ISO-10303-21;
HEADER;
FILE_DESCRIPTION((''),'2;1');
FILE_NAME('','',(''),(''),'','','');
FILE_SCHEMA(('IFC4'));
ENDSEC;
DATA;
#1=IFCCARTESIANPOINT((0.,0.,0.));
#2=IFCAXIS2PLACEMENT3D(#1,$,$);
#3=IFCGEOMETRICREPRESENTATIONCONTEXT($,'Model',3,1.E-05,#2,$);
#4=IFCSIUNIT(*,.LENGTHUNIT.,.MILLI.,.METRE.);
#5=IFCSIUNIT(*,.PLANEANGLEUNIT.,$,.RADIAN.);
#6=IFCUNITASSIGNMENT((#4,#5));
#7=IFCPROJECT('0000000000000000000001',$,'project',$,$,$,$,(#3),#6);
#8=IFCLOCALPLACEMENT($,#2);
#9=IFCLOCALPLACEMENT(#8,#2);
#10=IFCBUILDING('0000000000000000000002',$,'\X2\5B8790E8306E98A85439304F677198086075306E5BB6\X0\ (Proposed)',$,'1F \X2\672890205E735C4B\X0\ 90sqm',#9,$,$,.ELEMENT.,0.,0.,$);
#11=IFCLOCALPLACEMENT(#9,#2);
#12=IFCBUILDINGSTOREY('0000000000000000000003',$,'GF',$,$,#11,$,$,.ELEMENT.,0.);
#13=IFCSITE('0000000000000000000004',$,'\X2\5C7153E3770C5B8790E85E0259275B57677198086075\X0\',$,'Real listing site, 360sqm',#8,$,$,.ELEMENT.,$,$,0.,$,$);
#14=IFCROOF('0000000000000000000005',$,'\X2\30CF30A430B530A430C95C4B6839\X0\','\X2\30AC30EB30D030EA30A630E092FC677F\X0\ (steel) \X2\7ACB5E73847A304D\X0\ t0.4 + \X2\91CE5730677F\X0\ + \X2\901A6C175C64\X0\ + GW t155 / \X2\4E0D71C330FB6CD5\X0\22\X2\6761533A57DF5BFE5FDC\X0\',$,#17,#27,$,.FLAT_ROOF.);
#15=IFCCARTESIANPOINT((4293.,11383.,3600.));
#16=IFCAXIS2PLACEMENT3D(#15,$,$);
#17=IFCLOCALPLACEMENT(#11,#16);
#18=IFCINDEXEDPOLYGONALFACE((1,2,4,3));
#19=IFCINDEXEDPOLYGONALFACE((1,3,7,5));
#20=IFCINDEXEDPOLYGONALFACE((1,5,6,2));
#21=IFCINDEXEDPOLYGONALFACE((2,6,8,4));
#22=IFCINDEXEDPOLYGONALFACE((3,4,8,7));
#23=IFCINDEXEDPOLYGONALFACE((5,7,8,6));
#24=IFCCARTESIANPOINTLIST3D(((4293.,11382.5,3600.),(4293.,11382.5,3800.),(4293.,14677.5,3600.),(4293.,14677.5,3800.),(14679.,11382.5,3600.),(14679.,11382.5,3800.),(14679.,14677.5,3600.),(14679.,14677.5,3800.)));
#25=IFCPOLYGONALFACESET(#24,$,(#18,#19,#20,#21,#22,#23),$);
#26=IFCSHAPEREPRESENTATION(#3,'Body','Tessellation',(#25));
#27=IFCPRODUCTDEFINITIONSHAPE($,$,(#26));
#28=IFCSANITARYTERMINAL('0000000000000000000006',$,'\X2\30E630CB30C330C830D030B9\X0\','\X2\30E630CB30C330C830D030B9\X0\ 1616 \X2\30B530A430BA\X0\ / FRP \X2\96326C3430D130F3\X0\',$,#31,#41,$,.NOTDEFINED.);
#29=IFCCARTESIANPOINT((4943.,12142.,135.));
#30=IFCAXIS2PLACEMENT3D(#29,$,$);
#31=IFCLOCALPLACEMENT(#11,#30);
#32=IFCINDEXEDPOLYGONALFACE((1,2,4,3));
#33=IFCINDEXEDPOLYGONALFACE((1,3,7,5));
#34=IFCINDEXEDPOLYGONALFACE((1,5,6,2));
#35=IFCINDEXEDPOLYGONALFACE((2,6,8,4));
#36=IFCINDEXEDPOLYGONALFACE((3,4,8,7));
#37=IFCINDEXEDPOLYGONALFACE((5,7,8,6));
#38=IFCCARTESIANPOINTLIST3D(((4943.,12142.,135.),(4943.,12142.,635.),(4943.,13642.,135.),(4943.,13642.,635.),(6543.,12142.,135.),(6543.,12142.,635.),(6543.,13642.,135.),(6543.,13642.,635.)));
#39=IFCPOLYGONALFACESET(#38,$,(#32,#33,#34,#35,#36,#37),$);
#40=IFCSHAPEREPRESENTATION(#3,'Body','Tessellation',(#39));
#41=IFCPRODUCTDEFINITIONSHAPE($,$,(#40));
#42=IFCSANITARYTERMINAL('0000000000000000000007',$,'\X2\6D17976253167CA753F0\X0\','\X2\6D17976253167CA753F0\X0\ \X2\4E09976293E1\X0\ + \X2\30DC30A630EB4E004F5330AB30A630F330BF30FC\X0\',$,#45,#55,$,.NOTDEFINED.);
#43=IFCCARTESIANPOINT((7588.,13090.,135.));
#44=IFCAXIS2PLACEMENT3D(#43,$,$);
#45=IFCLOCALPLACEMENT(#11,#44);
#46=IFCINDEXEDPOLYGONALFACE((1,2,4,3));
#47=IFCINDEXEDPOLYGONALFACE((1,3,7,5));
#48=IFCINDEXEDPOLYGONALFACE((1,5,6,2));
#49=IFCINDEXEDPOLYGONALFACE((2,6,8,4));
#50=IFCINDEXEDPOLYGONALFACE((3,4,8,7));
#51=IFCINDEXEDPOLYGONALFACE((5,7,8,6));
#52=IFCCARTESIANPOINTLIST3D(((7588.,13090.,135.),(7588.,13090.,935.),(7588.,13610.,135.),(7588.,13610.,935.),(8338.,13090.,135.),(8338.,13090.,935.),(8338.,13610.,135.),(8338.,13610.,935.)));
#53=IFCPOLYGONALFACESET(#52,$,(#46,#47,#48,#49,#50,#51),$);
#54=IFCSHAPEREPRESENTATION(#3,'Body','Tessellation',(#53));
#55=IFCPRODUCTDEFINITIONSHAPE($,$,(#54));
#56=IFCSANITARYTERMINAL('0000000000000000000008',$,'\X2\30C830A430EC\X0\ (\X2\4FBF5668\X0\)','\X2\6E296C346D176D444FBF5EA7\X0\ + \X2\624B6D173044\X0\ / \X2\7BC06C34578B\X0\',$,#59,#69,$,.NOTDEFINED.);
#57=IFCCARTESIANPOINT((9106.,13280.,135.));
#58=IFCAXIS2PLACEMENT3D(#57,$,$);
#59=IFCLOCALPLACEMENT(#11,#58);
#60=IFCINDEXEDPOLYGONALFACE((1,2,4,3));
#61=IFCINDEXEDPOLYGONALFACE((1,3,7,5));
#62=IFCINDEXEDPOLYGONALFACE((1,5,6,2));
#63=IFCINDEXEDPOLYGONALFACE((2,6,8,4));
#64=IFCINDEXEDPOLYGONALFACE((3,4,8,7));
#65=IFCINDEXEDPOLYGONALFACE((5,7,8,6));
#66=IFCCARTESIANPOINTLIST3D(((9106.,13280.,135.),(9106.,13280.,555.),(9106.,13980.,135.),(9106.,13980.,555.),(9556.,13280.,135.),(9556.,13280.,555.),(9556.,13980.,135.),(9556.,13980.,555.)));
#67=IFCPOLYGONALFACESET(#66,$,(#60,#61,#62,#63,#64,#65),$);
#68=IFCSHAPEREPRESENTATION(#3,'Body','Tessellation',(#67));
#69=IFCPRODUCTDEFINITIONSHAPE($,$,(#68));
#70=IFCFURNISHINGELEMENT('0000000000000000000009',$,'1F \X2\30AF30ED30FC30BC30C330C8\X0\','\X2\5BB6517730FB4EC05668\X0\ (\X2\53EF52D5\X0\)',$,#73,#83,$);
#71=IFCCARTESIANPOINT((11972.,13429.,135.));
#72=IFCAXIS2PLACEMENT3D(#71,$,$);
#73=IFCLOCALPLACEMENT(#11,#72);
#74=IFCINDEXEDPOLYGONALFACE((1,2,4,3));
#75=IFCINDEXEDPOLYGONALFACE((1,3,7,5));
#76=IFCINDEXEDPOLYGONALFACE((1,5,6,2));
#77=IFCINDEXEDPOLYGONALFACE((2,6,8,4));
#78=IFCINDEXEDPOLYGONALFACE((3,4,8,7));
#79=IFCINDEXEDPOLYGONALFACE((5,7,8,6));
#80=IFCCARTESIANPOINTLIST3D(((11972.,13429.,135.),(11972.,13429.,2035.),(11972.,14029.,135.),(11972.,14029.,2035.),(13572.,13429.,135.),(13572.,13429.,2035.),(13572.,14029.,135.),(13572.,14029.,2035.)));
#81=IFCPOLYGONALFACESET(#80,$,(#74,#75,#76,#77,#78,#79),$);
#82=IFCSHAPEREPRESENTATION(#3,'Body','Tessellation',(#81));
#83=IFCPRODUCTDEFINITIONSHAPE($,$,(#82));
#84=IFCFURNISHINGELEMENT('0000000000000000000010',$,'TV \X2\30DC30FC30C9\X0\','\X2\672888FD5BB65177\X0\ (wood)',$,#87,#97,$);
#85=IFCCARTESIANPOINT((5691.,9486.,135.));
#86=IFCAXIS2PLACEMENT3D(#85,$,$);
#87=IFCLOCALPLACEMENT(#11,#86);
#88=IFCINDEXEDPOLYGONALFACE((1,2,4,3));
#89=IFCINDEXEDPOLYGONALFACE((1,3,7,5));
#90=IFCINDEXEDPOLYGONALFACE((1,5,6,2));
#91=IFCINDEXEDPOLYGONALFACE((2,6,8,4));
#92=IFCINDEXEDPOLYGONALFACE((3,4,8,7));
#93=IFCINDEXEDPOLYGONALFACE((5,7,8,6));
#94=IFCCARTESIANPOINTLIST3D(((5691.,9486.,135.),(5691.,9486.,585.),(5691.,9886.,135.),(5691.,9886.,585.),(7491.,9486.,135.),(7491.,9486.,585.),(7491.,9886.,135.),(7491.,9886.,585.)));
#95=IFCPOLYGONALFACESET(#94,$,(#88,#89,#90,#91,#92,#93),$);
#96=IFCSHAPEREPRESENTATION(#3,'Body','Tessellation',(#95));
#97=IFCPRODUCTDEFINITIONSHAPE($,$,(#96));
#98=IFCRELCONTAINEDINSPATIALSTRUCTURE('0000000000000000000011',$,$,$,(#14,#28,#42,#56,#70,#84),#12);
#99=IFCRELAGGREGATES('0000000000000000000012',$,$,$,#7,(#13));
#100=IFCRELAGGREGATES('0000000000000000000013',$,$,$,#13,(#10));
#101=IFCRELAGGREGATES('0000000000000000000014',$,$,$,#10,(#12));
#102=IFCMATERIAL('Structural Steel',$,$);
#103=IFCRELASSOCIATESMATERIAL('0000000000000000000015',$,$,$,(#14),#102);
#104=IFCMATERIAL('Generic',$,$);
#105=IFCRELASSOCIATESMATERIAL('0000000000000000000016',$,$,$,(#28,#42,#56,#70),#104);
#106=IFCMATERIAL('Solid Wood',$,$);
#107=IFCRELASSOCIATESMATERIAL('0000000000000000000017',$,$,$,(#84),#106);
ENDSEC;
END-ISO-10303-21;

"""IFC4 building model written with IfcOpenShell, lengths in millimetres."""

from ifc_helpers import new_model, si_unit, frame, frame_2d, origin, place, context, project, spatial, rectangle, extrude, material, element, save


model = new_model("IFC4")

# Units and contexts
model_context = context("Model", 3, precision=1e-05, world=origin())
ifc_project = project(units=[si_unit("LENGTHUNIT", "METRE", prefix="MILLI"), si_unit("PLANEANGLEUNIT", "RADIAN")], contexts=[model_context])

# Site, building, storey
site_placement = place(None, origin())
site = spatial("IfcSite", under=ifc_project, at=site_placement, Name="山口県宇部市大字東須恵", ObjectType="Real listing site, 360sqm", CompositionType="ELEMENT", RefElevation=0.0)
building_placement = place(site_placement, origin())
building = spatial("IfcBuilding", under=site, at=building_placement, Name="宇部の風吹く東須恵の家 (Proposed)", ObjectType="1F 木造平屋 90sqm", CompositionType="ELEMENT", ElevationOfRefHeight=0.0, ElevationOfTerrain=0.0)
storey_placement = place(building_placement, origin())
storey = spatial("IfcBuildingStorey", under=building, at=storey_placement, Name="GF", CompositionType="ELEMENT", Elevation=0.0)

# Shared definitions
ifc_material_1 = material(Name="Solid Wood")

# Roof
ifc_material_2 = material(Name="Structural Steel")
roof_placement = place(storey_placement, frame((4293.0, 11383.0, 3600.0)))
element("IfcRoof", 1, at=roof_placement, inside=storey, material=ifc_material_2, Name="ハイサイド屋根", Description="ガルバリウム鋼板 (steel) 立平葺き t0.4 + 野地板 + 通気層 + GW t155 / 不燃・法22条区域対応", PredefinedType="FLAT_ROOF", context=model_context, shape_type="SweptSolid", body=[
    extrude(rectangle(XDim=10386.0, YDim=3295.0, at=frame_2d((5193.0, 1647.0))), frame((4293.0, 11383.0, 3600.0)), (0.0, 0.0, 1.0), 200.0),
])

# Sanitary terminals
ifc_material_3 = material(Name="Generic")
sanitary_terminal_1_placement = place(storey_placement, frame((4943.0, 12142.0, 135.0)))
element("IfcSanitaryTerminal", 2, at=sanitary_terminal_1_placement, inside=storey, material=ifc_material_3, Name="ユニットバス", Description="ユニットバス 1616 サイズ / FRP 防水パン", PredefinedType="NOTDEFINED", context=model_context, shape_type="SweptSolid", body=[
    extrude(rectangle(XDim=1600.0, YDim=1500.0, at=frame_2d((800.0, 750.0))), frame((4943.0, 12142.0, 135.0)), (0.0, 0.0, 1.0), 500.0),
])
sanitary_terminal_2_placement = place(storey_placement, frame((7588.0, 13090.0, 135.0)))
element("IfcSanitaryTerminal", 3, at=sanitary_terminal_2_placement, inside=storey, material=ifc_material_3, Name="洗面化粧台", Description="洗面化粧台 三面鏡 + ボウル一体カウンター", PredefinedType="NOTDEFINED", context=model_context, shape_type="SweptSolid", body=[
    extrude(rectangle(XDim=750.0, YDim=520.0, at=frame_2d((375.0, 260.0))), frame((7588.0, 13090.0, 135.0)), (0.0, 0.0, 1.0), 800.0),
])
sanitary_terminal_3_placement = place(storey_placement, frame((9106.0, 13280.0, 135.0)))
element("IfcSanitaryTerminal", 4, at=sanitary_terminal_3_placement, inside=storey, material=ifc_material_3, Name="トイレ (便器)", Description="温水洗浄便座 + 手洗い / 節水型", PredefinedType="NOTDEFINED", context=model_context, shape_type="SweptSolid", body=[
    extrude(rectangle(XDim=450.0, YDim=700.0, at=frame_2d((225.0, 350.0))), frame((9106.0, 13280.0, 135.0)), (0.0, 0.0, 1.0), 420.0),
])

# Furnishing elements
furnishing_1_placement = place(storey_placement, frame((11972.0, 13429.0, 135.0)))
element("IfcFurnishingElement", 5, at=furnishing_1_placement, inside=storey, material=ifc_material_3, Name="1F クローゼット", Description="家具・什器 (可動)", context=model_context, shape_type="SweptSolid", body=[
    extrude(rectangle(XDim=1600.0, YDim=600.0, at=frame_2d((800.0, 300.0))), frame((11972.0, 13429.0, 135.0)), (0.0, 0.0, 1.0), 1900.0),
])
furnishing_2_placement = place(storey_placement, frame((5691.0, 9486.0, 135.0)))
element("IfcFurnishingElement", 6, at=furnishing_2_placement, inside=storey, material=ifc_material_1, Name="TV ボード", Description="木製家具 (wood)", context=model_context, shape_type="SweptSolid", body=[
    extrude(rectangle(XDim=1800.0, YDim=400.0, at=frame_2d((900.0, 200.0))), frame((5691.0, 9486.0, 135.0)), (0.0, 0.0, 1.0), 450.0),
])

save(model, "model.ifc")
